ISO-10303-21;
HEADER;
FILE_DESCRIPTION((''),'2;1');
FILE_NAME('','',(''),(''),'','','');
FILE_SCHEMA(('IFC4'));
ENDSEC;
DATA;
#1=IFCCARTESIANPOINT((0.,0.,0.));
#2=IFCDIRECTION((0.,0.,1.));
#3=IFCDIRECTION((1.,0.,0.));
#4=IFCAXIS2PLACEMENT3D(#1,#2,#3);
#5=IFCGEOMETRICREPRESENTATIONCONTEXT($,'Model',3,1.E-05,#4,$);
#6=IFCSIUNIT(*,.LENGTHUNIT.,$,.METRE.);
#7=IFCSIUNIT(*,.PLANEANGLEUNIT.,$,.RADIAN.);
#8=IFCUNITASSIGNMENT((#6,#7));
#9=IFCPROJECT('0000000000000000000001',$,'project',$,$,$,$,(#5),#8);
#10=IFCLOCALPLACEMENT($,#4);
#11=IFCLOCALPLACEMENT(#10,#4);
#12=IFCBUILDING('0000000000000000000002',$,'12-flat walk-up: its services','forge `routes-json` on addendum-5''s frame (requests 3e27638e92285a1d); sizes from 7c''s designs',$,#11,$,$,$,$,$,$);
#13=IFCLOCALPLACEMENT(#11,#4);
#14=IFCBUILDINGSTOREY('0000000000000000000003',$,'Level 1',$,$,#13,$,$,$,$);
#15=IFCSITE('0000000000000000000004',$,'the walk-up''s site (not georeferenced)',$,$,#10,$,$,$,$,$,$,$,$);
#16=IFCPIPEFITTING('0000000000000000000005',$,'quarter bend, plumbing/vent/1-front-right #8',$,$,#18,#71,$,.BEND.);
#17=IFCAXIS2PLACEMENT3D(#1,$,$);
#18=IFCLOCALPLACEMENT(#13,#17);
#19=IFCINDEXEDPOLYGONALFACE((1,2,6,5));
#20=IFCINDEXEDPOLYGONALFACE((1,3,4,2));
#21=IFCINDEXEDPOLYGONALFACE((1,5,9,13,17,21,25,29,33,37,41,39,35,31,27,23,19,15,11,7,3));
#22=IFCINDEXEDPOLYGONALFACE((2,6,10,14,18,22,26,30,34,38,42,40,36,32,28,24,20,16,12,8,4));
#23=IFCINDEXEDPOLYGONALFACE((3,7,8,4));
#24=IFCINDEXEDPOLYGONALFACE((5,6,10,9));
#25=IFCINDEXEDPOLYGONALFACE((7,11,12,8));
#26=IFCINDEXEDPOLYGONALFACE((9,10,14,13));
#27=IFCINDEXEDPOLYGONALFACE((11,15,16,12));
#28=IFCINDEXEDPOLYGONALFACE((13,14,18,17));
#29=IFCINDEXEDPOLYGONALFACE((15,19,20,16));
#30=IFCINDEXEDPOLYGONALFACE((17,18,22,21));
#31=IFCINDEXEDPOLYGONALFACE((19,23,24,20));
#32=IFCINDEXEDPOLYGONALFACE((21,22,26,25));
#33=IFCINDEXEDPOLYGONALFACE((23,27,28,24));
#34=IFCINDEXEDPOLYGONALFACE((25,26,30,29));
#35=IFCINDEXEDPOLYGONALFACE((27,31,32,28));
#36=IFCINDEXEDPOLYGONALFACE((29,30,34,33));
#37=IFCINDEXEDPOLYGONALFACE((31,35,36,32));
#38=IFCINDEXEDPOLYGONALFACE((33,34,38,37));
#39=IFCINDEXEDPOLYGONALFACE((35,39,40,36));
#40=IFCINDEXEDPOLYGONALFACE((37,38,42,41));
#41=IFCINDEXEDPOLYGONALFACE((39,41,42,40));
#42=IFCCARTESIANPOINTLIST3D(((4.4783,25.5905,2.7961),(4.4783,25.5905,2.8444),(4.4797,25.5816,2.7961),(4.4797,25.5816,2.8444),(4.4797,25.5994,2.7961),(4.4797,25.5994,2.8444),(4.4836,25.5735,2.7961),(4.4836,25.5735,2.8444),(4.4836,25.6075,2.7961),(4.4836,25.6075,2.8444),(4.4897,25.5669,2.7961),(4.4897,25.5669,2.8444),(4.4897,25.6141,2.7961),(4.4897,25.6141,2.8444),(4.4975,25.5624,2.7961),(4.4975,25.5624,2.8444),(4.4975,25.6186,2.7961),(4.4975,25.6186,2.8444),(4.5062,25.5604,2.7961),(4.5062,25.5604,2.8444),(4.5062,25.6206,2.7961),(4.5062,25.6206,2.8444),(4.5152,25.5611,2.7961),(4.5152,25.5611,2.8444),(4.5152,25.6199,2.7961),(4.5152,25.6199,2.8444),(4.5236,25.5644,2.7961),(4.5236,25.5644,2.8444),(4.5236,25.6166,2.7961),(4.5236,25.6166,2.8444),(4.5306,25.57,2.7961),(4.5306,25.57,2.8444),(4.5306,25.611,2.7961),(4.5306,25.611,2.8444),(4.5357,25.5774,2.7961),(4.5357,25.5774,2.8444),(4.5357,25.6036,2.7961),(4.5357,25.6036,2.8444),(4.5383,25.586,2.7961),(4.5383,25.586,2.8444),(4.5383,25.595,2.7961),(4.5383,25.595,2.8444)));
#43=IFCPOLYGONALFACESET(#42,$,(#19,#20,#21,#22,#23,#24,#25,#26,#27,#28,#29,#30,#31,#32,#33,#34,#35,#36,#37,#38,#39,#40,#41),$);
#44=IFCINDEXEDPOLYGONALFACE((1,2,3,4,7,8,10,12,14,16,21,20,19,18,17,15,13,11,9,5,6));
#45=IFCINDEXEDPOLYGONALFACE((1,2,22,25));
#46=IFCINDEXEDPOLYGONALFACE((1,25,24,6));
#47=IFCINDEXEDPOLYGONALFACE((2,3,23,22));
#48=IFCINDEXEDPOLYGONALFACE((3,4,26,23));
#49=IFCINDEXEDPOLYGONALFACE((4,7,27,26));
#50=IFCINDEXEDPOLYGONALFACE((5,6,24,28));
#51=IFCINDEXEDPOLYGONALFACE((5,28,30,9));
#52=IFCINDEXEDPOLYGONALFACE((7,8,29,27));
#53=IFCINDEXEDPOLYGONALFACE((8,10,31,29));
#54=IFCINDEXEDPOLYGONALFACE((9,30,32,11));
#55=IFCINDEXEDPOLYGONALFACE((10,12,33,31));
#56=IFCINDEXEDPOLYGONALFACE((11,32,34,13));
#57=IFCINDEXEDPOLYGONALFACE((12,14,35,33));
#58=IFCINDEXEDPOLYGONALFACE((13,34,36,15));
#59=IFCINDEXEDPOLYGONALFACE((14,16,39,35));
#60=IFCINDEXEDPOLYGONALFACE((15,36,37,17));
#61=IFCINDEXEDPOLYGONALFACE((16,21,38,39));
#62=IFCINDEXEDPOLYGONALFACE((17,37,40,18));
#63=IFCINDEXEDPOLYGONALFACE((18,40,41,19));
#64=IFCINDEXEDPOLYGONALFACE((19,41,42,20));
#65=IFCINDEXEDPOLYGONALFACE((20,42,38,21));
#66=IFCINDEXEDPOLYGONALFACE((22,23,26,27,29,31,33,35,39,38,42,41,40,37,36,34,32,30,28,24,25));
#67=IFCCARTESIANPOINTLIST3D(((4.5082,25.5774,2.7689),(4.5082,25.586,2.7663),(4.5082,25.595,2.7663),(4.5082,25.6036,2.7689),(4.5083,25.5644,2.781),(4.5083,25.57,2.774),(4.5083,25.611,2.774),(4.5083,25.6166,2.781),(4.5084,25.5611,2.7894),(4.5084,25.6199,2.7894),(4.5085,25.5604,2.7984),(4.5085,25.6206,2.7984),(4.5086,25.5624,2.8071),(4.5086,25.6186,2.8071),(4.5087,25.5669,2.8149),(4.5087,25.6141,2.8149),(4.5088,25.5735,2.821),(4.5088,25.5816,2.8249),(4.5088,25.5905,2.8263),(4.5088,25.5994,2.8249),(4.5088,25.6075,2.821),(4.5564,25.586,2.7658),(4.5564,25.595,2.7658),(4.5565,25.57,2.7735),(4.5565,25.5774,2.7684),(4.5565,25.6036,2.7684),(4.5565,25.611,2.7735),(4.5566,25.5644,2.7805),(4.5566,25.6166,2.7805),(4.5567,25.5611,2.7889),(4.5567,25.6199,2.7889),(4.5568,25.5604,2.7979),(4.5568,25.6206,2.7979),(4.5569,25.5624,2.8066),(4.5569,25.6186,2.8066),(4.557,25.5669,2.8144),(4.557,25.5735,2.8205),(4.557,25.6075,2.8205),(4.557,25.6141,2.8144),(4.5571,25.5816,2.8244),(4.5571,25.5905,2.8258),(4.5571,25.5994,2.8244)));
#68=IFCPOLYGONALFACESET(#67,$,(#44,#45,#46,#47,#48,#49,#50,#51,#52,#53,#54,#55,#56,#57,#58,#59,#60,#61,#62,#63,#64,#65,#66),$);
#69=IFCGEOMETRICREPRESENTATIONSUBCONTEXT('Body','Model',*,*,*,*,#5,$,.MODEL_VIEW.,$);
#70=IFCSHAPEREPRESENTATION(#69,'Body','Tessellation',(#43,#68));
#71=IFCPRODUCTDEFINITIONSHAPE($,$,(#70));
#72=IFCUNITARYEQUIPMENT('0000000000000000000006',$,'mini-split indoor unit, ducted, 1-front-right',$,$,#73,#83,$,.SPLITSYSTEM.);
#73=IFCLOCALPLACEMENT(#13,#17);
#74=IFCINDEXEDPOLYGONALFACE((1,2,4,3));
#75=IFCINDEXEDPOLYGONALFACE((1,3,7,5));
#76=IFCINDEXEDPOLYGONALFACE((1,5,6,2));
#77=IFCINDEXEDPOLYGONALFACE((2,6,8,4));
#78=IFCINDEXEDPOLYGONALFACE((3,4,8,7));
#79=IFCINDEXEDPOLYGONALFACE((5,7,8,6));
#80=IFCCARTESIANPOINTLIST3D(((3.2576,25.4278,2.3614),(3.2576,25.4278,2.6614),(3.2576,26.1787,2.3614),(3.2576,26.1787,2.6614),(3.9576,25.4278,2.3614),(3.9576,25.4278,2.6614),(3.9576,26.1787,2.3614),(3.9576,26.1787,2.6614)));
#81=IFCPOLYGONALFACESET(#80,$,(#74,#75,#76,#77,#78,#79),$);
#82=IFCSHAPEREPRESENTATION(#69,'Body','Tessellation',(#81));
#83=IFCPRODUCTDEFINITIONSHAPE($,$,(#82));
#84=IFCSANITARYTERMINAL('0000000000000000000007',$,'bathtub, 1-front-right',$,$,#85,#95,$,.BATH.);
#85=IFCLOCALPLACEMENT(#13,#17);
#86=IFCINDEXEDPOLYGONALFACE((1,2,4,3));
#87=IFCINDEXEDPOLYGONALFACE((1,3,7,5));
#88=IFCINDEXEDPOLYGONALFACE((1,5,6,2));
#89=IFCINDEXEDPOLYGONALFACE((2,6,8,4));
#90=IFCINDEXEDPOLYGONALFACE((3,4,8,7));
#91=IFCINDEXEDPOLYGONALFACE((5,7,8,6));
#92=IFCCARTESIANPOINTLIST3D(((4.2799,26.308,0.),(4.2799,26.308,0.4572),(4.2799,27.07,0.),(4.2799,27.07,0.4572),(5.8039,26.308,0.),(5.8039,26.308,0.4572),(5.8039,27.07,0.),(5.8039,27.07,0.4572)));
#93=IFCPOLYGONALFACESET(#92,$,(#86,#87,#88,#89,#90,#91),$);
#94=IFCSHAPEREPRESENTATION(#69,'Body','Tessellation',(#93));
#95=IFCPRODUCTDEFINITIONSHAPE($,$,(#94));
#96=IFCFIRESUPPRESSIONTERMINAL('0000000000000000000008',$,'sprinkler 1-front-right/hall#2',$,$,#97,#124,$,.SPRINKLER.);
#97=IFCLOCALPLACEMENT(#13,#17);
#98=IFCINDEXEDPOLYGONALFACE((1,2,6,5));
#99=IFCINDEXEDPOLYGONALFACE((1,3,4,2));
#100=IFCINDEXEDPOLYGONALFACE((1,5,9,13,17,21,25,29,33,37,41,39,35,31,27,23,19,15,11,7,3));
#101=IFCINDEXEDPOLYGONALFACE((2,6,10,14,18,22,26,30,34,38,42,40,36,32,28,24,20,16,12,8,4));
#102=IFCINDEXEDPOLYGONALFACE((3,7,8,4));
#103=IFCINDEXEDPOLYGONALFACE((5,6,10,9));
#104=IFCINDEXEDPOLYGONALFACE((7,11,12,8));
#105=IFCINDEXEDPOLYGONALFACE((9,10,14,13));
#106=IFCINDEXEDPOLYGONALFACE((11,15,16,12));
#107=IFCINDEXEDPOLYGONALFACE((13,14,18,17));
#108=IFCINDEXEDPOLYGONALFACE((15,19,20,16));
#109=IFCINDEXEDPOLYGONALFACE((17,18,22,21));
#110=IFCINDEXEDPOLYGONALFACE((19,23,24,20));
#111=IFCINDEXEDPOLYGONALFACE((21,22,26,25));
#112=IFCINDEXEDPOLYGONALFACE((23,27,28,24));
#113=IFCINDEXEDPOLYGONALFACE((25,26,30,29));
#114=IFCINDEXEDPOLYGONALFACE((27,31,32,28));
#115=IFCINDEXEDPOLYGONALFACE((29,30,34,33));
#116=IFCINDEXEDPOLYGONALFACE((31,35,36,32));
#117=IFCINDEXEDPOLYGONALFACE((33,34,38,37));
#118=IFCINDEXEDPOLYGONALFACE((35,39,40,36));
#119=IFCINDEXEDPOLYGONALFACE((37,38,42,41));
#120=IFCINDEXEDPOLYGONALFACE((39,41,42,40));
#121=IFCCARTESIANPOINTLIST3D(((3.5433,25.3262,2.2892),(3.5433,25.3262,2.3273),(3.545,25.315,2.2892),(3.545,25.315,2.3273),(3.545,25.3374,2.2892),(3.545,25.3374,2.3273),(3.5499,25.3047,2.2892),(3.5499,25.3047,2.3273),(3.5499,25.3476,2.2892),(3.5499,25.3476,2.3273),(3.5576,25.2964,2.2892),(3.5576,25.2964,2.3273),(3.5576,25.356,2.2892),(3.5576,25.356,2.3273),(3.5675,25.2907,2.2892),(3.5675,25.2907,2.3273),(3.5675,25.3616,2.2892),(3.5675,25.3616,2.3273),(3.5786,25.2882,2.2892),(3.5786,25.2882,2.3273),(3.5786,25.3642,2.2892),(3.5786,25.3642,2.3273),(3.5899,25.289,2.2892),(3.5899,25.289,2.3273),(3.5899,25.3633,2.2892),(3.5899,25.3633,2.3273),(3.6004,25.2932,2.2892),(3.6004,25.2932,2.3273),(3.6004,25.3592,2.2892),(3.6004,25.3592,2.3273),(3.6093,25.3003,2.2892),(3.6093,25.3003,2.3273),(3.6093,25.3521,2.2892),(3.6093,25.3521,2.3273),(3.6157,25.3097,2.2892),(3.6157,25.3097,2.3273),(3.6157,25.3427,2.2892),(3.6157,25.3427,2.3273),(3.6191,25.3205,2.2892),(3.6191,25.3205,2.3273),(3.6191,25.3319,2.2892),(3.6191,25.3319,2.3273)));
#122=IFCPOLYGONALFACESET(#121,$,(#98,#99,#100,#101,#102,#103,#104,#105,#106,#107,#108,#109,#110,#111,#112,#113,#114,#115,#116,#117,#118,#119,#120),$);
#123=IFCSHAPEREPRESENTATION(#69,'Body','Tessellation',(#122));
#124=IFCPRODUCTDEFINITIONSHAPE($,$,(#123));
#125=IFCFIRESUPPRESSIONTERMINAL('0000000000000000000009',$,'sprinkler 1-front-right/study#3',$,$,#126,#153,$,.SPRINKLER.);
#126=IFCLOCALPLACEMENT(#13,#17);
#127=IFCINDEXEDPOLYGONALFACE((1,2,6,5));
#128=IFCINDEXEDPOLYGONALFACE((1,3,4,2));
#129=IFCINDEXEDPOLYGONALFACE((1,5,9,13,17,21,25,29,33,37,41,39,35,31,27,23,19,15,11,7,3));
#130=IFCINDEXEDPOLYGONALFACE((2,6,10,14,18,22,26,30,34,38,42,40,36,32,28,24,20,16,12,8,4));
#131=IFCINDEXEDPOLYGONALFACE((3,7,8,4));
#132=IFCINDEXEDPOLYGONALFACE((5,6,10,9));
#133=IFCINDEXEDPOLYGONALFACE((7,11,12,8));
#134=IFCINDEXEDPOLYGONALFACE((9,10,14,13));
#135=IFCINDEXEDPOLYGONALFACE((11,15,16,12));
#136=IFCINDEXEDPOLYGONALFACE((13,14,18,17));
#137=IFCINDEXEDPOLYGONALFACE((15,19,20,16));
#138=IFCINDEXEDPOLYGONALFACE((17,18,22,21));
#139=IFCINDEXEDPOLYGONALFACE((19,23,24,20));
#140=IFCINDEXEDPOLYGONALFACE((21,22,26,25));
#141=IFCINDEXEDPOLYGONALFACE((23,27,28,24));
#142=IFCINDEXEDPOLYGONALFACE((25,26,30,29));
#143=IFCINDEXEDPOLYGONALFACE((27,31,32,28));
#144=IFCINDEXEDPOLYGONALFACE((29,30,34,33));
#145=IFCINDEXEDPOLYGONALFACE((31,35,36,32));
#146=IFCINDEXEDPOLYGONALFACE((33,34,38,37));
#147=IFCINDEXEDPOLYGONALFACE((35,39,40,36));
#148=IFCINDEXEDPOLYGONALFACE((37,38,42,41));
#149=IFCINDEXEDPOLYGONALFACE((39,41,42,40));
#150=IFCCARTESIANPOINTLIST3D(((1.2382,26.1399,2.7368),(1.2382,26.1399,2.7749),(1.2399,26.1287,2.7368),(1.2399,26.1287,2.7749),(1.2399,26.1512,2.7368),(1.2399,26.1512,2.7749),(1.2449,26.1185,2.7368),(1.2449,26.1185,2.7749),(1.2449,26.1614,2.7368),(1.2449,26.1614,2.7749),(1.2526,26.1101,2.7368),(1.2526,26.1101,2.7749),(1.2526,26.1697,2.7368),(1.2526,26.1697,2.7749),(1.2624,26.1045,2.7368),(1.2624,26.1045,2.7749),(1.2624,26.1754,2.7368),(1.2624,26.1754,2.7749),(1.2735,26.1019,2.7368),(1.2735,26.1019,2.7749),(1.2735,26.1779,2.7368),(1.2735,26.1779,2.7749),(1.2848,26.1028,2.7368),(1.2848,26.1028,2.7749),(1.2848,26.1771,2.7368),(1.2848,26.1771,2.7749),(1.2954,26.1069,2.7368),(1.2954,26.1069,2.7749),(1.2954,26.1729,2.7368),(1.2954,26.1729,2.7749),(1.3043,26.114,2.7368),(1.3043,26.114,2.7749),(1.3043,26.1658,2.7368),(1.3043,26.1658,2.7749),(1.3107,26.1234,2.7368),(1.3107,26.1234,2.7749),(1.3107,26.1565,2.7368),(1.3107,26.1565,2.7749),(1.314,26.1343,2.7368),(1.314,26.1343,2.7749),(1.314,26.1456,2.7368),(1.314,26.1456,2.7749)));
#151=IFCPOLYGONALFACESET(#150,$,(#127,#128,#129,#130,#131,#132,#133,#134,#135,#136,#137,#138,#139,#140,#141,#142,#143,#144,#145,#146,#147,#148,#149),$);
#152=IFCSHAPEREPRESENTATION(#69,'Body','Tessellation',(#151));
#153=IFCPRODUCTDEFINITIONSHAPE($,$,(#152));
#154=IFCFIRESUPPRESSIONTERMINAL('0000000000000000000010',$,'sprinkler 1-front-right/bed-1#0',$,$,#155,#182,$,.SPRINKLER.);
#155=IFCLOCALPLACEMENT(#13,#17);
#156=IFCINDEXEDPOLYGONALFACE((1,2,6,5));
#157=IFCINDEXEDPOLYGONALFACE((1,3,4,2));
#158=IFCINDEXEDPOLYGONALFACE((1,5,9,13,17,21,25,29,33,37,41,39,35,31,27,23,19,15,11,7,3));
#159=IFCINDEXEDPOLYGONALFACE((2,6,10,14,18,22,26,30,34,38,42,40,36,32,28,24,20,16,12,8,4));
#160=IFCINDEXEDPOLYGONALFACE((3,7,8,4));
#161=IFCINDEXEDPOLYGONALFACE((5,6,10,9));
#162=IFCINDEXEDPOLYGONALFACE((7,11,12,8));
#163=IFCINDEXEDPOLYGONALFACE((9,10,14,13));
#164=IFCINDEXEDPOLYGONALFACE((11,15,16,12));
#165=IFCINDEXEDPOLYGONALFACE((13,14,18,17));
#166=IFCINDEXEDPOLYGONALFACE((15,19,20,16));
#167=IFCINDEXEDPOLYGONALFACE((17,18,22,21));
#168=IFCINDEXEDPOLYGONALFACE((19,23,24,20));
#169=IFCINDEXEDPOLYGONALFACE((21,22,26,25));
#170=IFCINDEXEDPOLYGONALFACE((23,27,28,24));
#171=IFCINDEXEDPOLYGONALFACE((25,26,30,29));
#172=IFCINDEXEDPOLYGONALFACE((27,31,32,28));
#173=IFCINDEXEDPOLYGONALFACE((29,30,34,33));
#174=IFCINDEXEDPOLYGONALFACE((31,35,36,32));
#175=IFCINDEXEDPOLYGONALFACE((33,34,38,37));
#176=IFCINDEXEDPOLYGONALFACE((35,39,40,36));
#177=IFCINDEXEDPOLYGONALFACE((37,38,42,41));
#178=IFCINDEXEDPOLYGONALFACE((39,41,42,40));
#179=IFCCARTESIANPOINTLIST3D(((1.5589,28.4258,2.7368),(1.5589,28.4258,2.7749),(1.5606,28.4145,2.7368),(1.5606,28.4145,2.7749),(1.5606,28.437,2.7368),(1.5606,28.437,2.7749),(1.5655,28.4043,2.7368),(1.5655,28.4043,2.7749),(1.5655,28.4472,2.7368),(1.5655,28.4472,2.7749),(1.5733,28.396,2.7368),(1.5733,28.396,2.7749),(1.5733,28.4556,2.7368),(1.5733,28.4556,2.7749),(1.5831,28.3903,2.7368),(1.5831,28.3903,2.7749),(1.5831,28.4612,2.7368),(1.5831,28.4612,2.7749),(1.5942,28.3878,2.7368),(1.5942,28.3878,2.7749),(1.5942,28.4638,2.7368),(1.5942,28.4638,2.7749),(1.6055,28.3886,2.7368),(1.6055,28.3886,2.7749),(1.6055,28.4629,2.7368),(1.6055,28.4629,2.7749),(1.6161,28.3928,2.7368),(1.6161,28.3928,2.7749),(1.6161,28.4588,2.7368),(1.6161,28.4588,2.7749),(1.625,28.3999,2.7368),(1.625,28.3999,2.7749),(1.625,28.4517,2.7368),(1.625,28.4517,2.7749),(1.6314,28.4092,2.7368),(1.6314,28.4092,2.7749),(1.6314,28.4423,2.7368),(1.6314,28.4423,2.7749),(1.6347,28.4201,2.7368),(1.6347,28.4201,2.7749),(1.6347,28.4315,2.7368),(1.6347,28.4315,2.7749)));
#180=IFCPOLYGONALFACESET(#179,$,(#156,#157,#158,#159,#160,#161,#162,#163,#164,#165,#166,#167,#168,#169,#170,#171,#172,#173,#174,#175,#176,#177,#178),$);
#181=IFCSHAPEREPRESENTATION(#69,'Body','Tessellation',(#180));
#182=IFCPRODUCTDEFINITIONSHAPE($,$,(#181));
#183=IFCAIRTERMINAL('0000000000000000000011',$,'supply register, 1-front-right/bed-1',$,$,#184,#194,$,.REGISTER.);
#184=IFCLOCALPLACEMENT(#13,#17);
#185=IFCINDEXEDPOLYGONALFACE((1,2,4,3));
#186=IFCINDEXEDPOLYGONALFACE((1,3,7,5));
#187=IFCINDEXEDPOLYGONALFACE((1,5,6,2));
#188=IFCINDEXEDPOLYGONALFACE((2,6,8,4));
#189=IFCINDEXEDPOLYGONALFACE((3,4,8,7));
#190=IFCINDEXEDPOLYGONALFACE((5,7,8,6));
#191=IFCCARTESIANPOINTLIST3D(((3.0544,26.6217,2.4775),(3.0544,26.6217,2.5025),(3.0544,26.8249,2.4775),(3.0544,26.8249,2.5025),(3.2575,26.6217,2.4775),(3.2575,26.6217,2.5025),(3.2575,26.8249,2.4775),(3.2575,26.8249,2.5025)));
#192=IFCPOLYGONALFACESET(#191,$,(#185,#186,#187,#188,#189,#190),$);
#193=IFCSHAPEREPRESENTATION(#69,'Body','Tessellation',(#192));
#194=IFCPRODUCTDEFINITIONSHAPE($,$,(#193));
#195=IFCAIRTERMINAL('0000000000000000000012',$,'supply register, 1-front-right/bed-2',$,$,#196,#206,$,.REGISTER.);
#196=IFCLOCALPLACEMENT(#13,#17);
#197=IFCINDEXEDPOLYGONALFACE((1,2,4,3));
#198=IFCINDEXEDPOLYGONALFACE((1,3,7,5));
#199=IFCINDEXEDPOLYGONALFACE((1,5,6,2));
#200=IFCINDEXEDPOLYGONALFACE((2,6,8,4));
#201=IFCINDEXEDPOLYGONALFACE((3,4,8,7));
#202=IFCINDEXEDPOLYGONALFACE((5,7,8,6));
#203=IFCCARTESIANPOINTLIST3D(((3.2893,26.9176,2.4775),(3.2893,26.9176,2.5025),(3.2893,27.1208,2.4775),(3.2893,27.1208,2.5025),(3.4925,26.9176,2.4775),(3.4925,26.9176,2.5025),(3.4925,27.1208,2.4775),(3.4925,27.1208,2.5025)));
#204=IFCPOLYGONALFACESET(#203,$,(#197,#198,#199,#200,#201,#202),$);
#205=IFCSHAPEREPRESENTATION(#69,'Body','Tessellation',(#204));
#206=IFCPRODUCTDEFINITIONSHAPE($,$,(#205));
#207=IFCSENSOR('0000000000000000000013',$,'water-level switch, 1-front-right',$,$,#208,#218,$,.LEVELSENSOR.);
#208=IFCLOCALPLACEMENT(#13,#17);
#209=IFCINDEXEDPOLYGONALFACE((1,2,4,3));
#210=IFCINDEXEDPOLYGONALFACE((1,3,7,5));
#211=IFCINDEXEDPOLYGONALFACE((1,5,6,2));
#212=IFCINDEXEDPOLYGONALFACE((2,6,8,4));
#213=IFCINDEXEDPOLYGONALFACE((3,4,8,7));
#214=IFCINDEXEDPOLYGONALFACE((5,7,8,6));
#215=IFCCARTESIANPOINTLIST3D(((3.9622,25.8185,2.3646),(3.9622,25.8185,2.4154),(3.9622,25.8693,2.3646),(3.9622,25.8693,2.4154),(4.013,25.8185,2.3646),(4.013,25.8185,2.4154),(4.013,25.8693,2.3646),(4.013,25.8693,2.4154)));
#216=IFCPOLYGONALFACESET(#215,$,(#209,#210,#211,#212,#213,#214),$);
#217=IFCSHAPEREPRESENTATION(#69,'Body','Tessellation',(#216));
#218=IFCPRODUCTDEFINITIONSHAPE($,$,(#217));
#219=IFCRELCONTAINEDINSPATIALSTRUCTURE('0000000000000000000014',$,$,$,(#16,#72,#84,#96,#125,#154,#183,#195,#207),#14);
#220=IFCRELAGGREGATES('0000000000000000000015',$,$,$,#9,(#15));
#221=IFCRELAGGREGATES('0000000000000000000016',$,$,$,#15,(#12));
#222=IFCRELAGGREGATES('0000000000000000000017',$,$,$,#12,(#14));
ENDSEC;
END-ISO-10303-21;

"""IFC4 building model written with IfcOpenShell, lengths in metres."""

from ifc_helpers import new_model, entity, si_unit, frame, frame_2d, origin, origin_with_axes, place, context, subcontext, project, spatial, rectangle, extrude, element, save


model = new_model("IFC4")

# Units and contexts
model_context = context("Model", 3, precision=1e-05, world=origin_with_axes())
body_context = subcontext(model_context, "Body", "Model", "MODEL_VIEW")
ifc_project = project(units=[si_unit("LENGTHUNIT", "METRE"), si_unit("PLANEANGLEUNIT", "RADIAN")], contexts=[model_context])

# Site, building, storey
site_placement = place(None, origin_with_axes())
site = spatial("IfcSite", under=ifc_project, at=site_placement, Name="the walk-up's site (not georeferenced)")
building_placement = place(site_placement, origin_with_axes())
building = spatial("IfcBuilding", under=site, at=building_placement, Name="12-flat walk-up: its services", Description="forge `routes-json` on addendum-5's frame (requests 3e27638e92285a1d); sizes from 7c's designs")
storey_placement = place(building_placement, origin_with_axes())
storey = spatial("IfcBuildingStorey", under=building, at=storey_placement, Name="Level 1")

# Pipe fitting
pipe_fitting_1_placement = place(storey_placement, frame((4.5085, 25.5905, 2.8444), z_axis=(0.0, 0.0, 1.0), x_axis=(1.0, 0.0, 0.0)))
element("IfcPipeFitting", 1, at=pipe_fitting_1_placement, inside=storey, Name="quarter bend, plumbing/vent/1-front-right #8", PredefinedType="BEND", context=body_context, shape_type="AdvancedSweptSolid", body=[
    entity("IfcSweptDiskSolid", entity("IfcPolyline", [entity("IfcCartesianPoint", [0.0, 0.0, 0.0]), entity("IfcCartesianPoint", [0.0, 0.0, -0.0483])]), 0.0302),
    entity("IfcSweptDiskSolid", entity("IfcPolyline", [entity("IfcCartesianPoint", [0.0, 0.0, -0.0483]), entity("IfcCartesianPoint", [0.0483, 0.0, -0.0488])]), 0.0302),
])

# Unitary equipment
unitary_equipment_placement = place(storey_placement, frame((3.2576, 25.4278, 2.3614), z_axis=(0.0, 0.0, 1.0), x_axis=(1.0, 0.0, 0.0)))
element("IfcUnitaryEquipment", 2, at=unitary_equipment_placement, inside=storey, Name="mini-split indoor unit, ducted, 1-front-right", PredefinedType="SPLITSYSTEM", context=body_context, shape_type="SweptSolid", body=[
    extrude(rectangle(XDim=0.7001, YDim=0.7509, at=frame_2d((0.35, 0.3754))), origin(), (0.0, 0.0, 1.0), 0.3),
])

# Sanitary terminal
sanitary_terminal_placement = place(storey_placement, frame((4.2799, 26.308, 0.0), z_axis=(0.0, 0.0, 1.0), x_axis=(1.0, 0.0, 0.0)))
element("IfcSanitaryTerminal", 3, at=sanitary_terminal_placement, inside=storey, Name="bathtub, 1-front-right", PredefinedType="BATH", context=body_context, shape_type="SweptSolid", body=[
    extrude(rectangle(XDim=1.524, YDim=0.762, at=frame_2d((0.762, 0.381))), origin(), (0.0, 0.0, 1.0), 0.4572),
])

# Fire suppression terminals
for number, where, z_axis, x_axis, name in (
    (4, (3.5814, 25.3262, 2.3273), (0.0, 0.0, 1.0), (1.0, 0.0, 0.0), "sprinkler 1-front-right/hall#2"),
    (5, (1.2764, 26.1399, 2.7749), (0.0, 0.0, 1.0), (1.0, 0.0, 0.0), "sprinkler 1-front-right/study#3"),
    (6, (1.597, 28.4258, 2.7749), (0.0, 0.0, 1.0), (1.0, 0.0, 0.0), "sprinkler 1-front-right/bed-1#0"),
):
    element("IfcFireSuppressionTerminal", number, at=place(storey_placement, frame(where, z_axis=z_axis, x_axis=x_axis)), inside=storey, Name=name, PredefinedType="SPRINKLER", context=body_context, shape_type="AdvancedSweptSolid", body=[
        entity("IfcSweptDiskSolid", entity("IfcPolyline", [entity("IfcCartesianPoint", [0.0, 0.0, 0.0]), entity("IfcCartesianPoint", [0.0, 0.0, -0.0381])]), 0.0381),
    ])

# Air terminals
for number, where, z_axis, x_axis, name in (
    (7, (3.0543, 26.6217, 2.4775), (0.0, 0.0, 1.0), (1.0, 0.0, 0.0), "supply register, 1-front-right/bed-1"),
    (8, (3.2893, 26.9176, 2.4775), (0.0, 0.0, 1.0), (1.0, 0.0, 0.0), "supply register, 1-front-right/bed-2"),
):
    element("IfcAirTerminal", number, at=place(storey_placement, frame(where, z_axis=z_axis, x_axis=x_axis)), inside=storey, Name=name, PredefinedType="REGISTER", context=body_context, shape_type="SweptSolid", body=[
        extrude(rectangle(XDim=0.2032, YDim=0.2032, at=frame_2d((0.1016, 0.1016))), origin(), (0.0, 0.0, 1.0), 0.025),
    ])

# Sensor
sensor_placement = place(storey_placement, frame((3.9622, 25.8185, 2.3646), z_axis=(0.0, 0.0, 1.0), x_axis=(1.0, 0.0, 0.0)))
element("IfcSensor", 9, at=sensor_placement, inside=storey, Name="water-level switch, 1-front-right", PredefinedType="LEVELSENSOR", context=body_context, shape_type="SweptSolid", body=[
    extrude(rectangle(XDim=0.0508, YDim=0.0508, at=frame_2d((0.0254, 0.0254))), origin(), (0.0, 0.0, 1.0), 0.0508),
])

save(model, "model.ifc")
